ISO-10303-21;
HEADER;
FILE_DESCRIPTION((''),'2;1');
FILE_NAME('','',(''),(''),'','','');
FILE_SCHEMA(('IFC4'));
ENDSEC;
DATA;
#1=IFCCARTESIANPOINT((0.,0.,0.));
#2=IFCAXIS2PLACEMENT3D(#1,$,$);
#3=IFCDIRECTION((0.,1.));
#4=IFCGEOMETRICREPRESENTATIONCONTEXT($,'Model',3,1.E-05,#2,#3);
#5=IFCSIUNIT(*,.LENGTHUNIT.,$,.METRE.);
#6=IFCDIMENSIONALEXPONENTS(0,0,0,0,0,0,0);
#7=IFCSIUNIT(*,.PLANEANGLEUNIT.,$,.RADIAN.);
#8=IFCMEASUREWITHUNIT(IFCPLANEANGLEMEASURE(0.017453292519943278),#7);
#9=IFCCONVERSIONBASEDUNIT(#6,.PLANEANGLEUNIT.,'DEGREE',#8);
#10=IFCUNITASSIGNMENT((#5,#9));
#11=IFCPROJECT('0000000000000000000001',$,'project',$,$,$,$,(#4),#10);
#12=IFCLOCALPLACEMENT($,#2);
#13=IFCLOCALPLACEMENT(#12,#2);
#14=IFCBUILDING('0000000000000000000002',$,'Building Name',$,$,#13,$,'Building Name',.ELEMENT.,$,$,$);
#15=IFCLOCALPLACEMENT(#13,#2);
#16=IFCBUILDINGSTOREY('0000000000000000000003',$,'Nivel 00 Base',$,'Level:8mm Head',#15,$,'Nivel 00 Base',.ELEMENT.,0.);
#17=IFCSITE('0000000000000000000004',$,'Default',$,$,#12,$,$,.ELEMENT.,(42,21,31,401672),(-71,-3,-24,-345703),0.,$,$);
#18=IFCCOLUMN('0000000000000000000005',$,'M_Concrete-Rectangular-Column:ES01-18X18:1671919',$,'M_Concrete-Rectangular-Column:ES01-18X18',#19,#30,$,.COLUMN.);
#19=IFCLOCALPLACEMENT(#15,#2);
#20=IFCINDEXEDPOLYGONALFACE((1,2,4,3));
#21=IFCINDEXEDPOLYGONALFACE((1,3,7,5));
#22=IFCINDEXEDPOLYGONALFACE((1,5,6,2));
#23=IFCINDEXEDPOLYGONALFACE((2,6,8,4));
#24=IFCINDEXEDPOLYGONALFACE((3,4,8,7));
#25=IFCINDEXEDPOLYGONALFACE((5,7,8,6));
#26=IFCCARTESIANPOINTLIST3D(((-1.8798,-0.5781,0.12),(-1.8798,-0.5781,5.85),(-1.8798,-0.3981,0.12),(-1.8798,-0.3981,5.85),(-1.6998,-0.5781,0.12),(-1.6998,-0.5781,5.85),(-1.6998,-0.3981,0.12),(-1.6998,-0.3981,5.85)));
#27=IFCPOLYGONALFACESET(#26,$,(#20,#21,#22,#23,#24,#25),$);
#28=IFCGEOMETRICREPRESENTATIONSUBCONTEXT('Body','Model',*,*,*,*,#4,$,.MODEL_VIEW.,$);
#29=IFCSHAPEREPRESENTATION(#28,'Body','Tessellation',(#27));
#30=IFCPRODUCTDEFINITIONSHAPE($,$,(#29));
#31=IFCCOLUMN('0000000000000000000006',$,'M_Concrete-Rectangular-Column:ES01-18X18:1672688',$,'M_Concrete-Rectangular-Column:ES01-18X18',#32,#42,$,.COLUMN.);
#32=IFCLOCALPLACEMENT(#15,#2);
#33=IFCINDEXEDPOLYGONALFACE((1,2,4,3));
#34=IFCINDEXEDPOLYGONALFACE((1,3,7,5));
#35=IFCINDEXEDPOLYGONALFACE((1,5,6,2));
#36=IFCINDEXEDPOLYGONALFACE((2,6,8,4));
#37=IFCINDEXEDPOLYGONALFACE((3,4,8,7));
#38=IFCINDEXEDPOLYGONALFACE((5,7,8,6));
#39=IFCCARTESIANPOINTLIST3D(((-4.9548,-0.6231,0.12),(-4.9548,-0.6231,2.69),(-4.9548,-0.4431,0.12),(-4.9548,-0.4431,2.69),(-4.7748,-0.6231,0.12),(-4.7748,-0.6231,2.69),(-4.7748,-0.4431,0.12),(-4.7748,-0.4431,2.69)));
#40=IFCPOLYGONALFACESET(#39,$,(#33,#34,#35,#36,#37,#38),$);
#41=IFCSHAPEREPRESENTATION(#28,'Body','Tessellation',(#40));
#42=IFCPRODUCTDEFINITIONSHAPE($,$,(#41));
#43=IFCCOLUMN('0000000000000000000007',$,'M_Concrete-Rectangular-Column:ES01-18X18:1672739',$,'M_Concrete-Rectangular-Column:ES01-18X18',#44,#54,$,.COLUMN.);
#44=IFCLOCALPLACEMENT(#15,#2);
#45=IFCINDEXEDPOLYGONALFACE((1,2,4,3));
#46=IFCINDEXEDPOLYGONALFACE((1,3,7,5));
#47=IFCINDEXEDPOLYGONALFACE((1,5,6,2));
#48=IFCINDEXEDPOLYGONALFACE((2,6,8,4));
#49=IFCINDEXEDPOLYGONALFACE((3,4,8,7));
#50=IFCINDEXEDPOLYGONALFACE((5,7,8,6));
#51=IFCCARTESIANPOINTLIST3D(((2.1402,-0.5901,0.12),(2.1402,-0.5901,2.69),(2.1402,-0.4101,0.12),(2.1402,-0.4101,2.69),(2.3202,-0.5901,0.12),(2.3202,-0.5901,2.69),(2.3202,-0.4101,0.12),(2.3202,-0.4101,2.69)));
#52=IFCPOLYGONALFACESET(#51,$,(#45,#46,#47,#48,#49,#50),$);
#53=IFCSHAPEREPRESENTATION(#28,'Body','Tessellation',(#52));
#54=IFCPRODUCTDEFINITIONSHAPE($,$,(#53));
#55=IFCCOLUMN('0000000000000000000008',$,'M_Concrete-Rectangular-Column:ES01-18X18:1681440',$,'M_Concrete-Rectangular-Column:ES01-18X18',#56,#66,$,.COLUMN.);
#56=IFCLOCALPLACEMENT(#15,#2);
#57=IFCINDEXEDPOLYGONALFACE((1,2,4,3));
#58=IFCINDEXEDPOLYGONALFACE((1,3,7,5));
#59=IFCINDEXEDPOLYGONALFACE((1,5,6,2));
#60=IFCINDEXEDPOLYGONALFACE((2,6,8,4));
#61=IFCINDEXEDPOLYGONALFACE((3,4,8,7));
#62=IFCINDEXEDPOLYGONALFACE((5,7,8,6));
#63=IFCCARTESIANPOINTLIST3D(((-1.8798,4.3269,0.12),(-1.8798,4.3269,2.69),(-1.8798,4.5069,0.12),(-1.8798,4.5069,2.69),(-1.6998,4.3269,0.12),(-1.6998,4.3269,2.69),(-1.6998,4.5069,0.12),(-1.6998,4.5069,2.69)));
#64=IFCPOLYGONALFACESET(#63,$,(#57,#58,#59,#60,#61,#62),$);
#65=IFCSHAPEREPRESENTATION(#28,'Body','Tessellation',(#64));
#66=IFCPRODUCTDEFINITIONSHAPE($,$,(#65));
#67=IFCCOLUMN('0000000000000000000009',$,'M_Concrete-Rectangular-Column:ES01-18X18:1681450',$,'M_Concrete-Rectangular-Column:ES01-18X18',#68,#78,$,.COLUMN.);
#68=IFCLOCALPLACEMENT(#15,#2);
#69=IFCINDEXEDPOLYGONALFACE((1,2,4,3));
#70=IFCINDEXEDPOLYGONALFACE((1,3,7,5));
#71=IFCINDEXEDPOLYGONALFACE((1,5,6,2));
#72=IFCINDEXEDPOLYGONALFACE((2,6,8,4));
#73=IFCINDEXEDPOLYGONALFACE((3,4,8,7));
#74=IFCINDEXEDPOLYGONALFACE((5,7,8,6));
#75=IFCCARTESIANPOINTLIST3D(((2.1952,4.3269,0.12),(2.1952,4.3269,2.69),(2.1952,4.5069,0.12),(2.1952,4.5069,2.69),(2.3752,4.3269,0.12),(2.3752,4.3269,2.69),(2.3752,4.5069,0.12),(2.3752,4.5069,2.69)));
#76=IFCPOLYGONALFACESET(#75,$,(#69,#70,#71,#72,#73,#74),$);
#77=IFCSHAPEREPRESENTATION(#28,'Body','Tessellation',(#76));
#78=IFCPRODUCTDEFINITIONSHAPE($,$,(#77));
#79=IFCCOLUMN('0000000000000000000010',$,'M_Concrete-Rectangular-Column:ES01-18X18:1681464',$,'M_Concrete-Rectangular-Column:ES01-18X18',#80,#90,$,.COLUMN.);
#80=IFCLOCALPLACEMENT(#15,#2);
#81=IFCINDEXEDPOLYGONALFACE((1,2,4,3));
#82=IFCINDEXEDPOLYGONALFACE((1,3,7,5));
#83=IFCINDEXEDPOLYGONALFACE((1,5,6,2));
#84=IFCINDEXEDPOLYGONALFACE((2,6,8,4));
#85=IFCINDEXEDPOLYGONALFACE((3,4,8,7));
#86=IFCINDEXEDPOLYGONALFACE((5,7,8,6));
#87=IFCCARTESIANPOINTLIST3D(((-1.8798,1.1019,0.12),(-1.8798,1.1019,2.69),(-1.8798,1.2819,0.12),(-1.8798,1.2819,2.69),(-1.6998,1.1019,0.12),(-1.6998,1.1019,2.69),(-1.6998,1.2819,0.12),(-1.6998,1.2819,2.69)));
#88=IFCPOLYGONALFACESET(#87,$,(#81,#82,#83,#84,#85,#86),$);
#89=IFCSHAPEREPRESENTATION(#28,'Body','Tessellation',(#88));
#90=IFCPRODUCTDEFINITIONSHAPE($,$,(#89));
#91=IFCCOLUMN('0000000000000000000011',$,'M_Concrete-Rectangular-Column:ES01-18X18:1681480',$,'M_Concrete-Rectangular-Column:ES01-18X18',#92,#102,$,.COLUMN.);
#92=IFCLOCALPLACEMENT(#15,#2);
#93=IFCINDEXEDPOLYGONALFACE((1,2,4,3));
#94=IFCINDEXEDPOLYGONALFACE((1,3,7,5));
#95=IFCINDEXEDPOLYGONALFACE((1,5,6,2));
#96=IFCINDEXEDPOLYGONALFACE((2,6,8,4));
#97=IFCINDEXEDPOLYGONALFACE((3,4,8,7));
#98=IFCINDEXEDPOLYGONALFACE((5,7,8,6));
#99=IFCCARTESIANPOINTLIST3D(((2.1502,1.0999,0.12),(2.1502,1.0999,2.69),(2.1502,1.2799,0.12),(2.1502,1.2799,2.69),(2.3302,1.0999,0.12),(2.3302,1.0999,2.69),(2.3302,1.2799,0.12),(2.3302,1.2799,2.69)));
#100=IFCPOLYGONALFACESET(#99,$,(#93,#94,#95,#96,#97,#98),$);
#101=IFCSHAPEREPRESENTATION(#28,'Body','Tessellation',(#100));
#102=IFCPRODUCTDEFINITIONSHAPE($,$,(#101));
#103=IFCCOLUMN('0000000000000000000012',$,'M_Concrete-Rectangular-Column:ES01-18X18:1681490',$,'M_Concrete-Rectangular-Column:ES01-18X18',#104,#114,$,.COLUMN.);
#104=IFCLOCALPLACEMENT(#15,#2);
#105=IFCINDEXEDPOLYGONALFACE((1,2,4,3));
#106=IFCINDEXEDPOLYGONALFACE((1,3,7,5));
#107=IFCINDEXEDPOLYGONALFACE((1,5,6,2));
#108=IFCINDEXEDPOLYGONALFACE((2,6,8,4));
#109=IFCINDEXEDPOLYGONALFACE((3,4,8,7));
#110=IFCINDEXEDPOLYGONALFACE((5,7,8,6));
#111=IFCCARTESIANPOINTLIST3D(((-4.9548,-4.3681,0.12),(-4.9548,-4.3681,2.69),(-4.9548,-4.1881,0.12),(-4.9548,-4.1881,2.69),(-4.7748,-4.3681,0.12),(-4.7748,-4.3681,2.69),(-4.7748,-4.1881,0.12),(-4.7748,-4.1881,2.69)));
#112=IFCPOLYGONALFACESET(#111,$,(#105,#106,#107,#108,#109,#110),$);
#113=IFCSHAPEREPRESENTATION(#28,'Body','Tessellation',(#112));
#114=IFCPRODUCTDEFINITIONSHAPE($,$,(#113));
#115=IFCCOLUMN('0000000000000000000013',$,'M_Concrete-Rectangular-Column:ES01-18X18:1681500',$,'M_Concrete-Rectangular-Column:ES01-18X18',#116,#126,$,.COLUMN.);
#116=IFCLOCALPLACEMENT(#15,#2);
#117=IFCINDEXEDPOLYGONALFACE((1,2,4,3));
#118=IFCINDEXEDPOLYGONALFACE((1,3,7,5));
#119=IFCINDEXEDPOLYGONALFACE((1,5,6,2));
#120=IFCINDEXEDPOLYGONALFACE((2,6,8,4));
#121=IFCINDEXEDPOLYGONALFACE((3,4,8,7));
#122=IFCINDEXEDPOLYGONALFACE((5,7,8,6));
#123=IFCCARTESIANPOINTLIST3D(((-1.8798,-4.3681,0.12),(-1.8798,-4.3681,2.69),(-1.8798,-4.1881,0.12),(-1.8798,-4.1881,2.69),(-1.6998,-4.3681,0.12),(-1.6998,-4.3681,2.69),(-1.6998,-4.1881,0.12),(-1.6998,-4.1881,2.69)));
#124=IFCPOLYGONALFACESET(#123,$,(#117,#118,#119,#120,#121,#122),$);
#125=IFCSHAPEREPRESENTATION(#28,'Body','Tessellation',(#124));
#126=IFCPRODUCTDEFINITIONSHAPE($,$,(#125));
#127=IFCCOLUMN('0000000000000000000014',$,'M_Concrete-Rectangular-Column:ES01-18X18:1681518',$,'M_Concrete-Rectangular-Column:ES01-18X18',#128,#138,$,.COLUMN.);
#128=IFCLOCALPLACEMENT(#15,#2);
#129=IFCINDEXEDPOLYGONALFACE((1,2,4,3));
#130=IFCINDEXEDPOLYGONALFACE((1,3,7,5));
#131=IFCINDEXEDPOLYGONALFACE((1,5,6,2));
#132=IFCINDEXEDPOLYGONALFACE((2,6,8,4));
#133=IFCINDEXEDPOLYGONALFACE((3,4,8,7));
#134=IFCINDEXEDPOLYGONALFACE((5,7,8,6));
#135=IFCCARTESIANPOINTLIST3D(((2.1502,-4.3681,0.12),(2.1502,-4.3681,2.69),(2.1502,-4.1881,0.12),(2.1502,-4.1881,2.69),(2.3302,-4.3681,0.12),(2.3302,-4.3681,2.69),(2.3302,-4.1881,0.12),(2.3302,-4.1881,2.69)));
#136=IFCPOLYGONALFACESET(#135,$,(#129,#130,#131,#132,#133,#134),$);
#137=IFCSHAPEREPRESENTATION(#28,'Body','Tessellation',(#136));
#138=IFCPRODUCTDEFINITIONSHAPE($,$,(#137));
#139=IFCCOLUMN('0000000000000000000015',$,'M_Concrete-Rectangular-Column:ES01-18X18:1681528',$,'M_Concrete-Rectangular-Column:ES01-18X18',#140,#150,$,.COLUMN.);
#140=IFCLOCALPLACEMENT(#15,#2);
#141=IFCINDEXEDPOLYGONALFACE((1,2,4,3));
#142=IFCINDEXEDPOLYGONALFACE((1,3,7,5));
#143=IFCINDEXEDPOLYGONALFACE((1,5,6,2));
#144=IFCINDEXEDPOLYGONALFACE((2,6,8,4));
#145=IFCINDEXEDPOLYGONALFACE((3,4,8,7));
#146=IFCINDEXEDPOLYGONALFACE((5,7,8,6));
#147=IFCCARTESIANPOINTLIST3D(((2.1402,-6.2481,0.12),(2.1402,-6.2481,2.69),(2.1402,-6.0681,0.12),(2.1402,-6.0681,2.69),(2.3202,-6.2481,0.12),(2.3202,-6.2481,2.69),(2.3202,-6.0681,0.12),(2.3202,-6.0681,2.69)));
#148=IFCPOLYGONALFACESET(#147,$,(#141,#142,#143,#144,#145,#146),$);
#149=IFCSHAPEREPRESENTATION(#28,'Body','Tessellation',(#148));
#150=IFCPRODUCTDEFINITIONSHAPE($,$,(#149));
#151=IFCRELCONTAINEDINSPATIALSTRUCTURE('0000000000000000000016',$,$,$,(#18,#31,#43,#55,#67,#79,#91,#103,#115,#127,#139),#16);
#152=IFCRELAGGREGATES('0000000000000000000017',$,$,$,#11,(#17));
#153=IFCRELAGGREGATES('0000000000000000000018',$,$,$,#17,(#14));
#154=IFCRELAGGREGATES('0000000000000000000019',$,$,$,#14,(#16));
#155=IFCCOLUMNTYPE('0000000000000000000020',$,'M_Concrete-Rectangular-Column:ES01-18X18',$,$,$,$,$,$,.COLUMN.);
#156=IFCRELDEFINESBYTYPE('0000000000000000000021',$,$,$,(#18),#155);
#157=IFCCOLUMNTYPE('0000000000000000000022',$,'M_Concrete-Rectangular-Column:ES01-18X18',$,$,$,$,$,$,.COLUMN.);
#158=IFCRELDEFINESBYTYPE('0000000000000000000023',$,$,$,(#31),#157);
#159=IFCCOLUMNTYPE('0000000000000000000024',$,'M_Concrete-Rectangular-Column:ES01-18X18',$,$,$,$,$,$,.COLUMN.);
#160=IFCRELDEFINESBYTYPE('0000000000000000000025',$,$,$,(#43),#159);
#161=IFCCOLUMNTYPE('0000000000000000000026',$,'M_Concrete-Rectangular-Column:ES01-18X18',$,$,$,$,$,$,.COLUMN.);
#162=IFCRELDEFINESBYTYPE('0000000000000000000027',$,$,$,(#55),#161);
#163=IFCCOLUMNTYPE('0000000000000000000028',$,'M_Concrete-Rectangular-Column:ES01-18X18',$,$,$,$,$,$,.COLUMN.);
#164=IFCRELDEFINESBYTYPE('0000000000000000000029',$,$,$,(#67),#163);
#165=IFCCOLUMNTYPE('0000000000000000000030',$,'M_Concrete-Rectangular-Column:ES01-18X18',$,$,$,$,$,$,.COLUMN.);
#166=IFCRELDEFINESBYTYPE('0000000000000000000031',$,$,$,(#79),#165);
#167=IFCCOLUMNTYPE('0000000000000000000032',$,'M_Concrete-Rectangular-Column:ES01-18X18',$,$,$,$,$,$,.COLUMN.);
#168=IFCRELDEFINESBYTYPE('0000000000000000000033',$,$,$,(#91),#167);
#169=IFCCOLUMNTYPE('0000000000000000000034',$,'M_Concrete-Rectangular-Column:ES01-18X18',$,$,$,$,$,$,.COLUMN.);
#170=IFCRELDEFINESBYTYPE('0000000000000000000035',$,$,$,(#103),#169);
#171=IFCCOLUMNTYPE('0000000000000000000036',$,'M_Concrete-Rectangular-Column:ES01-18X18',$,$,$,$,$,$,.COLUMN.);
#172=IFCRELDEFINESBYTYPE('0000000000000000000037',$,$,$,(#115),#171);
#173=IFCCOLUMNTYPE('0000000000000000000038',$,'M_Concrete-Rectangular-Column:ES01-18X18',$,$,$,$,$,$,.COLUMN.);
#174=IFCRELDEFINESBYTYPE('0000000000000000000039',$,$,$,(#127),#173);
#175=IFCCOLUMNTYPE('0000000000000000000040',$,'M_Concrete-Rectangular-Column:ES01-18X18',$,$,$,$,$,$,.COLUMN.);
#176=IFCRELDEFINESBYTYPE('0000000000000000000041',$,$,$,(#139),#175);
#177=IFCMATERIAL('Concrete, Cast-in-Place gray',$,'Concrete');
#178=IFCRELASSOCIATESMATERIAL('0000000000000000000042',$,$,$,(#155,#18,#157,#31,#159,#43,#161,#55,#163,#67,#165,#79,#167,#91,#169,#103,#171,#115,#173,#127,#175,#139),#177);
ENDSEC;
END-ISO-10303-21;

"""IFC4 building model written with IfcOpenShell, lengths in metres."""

from ifc_helpers import new_model, entity, si_unit, converted_unit, direction, frame, origin, place, context, subcontext, project, spatial, indexed_curve, outline, extrude, source, transform, mapped, material, type_object, type_shapes, element, save


model = new_model("IFC4")

# Units and contexts
model_context = context("Model", 3, precision=1e-05, world=origin(), true_north=direction((0.0, 1.0)))
body_context = subcontext(model_context, "Body", "Model", "MODEL_VIEW")
ifc_project = project(units=[si_unit("LENGTHUNIT", "METRE"), converted_unit("PLANEANGLEUNIT", "DEGREE", entity("IfcPlaneAngleMeasure", 0.017453292519943278), si_unit("PLANEANGLEUNIT", "RADIAN"), dimensions=[0, 0, 0, 0, 0, 0, 0])], contexts=[model_context])

# Site, building, storey
site_placement = place(None, origin())
site = spatial("IfcSite", under=ifc_project, at=site_placement, Name="Default", CompositionType="ELEMENT", RefLatitude=(42, 21, 31, 401672), RefLongitude=(-71, -3, -24, -345703), RefElevation=0.0)
building_placement = place(site_placement, origin())
building = spatial("IfcBuilding", under=site, at=building_placement, Name="Building Name", LongName="Building Name", CompositionType="ELEMENT")
storey_placement = place(building_placement, origin())
storey = spatial("IfcBuildingStorey", under=building, at=storey_placement, Name="Nivel 00 Base", ObjectType="Level:8mm Head", LongName="Nivel 00 Base", CompositionType="ELEMENT", Elevation=0.0)

# Columns
ifc_material_1 = material(Name="Concrete, Cast-in-Place gray", Category="Concrete")
column_type_1 = type_object("IfcColumnType", Name="M_Concrete-Rectangular-Column:ES01-18X18", PredefinedType="COLUMN", material=ifc_material_1)
shared_shape_1 = source(origin(), body_context, "Body", "SweptSolid", [
    extrude(outline(indexed_curve([(-0.09, -0.09), (0.09, -0.09), (0.09, 0.09), (-0.09, 0.09), (-0.09, -0.09)], self_intersect=False)), frame((-1.7898, -0.4881, 0.12), z_axis=(0.0, 0.0, 1.0), x_axis=(-1.0, 0.0, 0.0)), (0.0, 0.0, 1.0), 5.73),
])
type_shapes(column_type_1, [shared_shape_1])
column_1_placement = place(storey_placement, origin())
element("IfcColumn", 1, at=column_1_placement, inside=storey, type_object=column_type_1, material=ifc_material_1, Name="M_Concrete-Rectangular-Column:ES01-18X18:1671919", ObjectType="M_Concrete-Rectangular-Column:ES01-18X18", PredefinedType="COLUMN", context=body_context, shape_type="MappedRepresentation", body=[
    mapped(shared_shape_1, transform((0.0, 0.0, 0.0), scale=1.0)),
])
column_type_2 = type_object("IfcColumnType", Name="M_Concrete-Rectangular-Column:ES01-18X18", PredefinedType="COLUMN", material=ifc_material_1)
shared_shape_2 = source(origin(), body_context, "Body", "SweptSolid", [
    extrude(outline(indexed_curve([(-0.09, -0.09), (0.09, -0.09), (0.09, 0.09), (-0.09, 0.09), (-0.09, -0.09)], self_intersect=False)), frame((-4.8648, -0.5331, 0.12), z_axis=(0.0, 0.0, 1.0), x_axis=(-1.0, 0.0, 0.0)), (0.0, 0.0, 1.0), 2.57),
])
type_shapes(column_type_2, [shared_shape_2])
column_2_placement = place(storey_placement, origin())
element("IfcColumn", 2, at=column_2_placement, inside=storey, type_object=column_type_2, material=ifc_material_1, Name="M_Concrete-Rectangular-Column:ES01-18X18:1672688", ObjectType="M_Concrete-Rectangular-Column:ES01-18X18", PredefinedType="COLUMN", context=body_context, shape_type="MappedRepresentation", body=[
    mapped(shared_shape_2, transform((0.0, 0.0, 0.0), scale=1.0)),
])
column_type_3 = type_object("IfcColumnType", Name="M_Concrete-Rectangular-Column:ES01-18X18", PredefinedType="COLUMN", material=ifc_material_1)
shared_shape_3 = source(origin(), body_context, "Body", "SweptSolid", [
    extrude(outline(indexed_curve([(-0.09, -0.09), (0.09, -0.09), (0.09, 0.09), (-0.09, 0.09), (-0.09, -0.09)], self_intersect=False)), frame((2.2302, -0.5001, 0.12), z_axis=(0.0, 0.0, 1.0), x_axis=(-1.0, 0.0, 0.0)), (0.0, 0.0, 1.0), 2.57),
])
type_shapes(column_type_3, [shared_shape_3])
column_3_placement = place(storey_placement, origin())
element("IfcColumn", 3, at=column_3_placement, inside=storey, type_object=column_type_3, material=ifc_material_1, Name="M_Concrete-Rectangular-Column:ES01-18X18:1672739", ObjectType="M_Concrete-Rectangular-Column:ES01-18X18", PredefinedType="COLUMN", context=body_context, shape_type="MappedRepresentation", body=[
    mapped(shared_shape_3, transform((0.0, 0.0, 0.0), scale=1.0)),
])
column_type_4 = type_object("IfcColumnType", Name="M_Concrete-Rectangular-Column:ES01-18X18", PredefinedType="COLUMN", material=ifc_material_1)
shared_shape_4 = source(origin(), body_context, "Body", "SweptSolid", [
    extrude(outline(indexed_curve([(-0.09, -0.09), (0.09, -0.09), (0.09, 0.09), (-0.09, 0.09), (-0.09, -0.09)], self_intersect=False)), frame((-1.7898, 4.4169, 0.12), z_axis=(0.0, 0.0, 1.0), x_axis=(-1.0, 0.0, 0.0)), (0.0, 0.0, 1.0), 2.57),
])
type_shapes(column_type_4, [shared_shape_4])
column_4_placement = place(storey_placement, origin())
element("IfcColumn", 4, at=column_4_placement, inside=storey, type_object=column_type_4, material=ifc_material_1, Name="M_Concrete-Rectangular-Column:ES01-18X18:1681440", ObjectType="M_Concrete-Rectangular-Column:ES01-18X18", PredefinedType="COLUMN", context=body_context, shape_type="MappedRepresentation", body=[
    mapped(shared_shape_4, transform((0.0, 0.0, 0.0), scale=1.0)),
])
column_type_5 = type_object("IfcColumnType", Name="M_Concrete-Rectangular-Column:ES01-18X18", PredefinedType="COLUMN", material=ifc_material_1)
shared_shape_5 = source(origin(), body_context, "Body", "SweptSolid", [
    extrude(outline(indexed_curve([(-0.09, -0.09), (0.09, -0.09), (0.09, 0.09), (-0.09, 0.09), (-0.09, -0.09)], self_intersect=False)), frame((2.2852, 4.4169, 0.12), z_axis=(0.0, 0.0, 1.0), x_axis=(-1.0, 0.0, 0.0)), (0.0, 0.0, 1.0), 2.57),
])
type_shapes(column_type_5, [shared_shape_5])
column_5_placement = place(storey_placement, origin())
element("IfcColumn", 5, at=column_5_placement, inside=storey, type_object=column_type_5, material=ifc_material_1, Name="M_Concrete-Rectangular-Column:ES01-18X18:1681450", ObjectType="M_Concrete-Rectangular-Column:ES01-18X18", PredefinedType="COLUMN", context=body_context, shape_type="MappedRepresentation", body=[
    mapped(shared_shape_5, transform((0.0, 0.0, 0.0), scale=1.0)),
])
column_type_6 = type_object("IfcColumnType", Name="M_Concrete-Rectangular-Column:ES01-18X18", PredefinedType="COLUMN", material=ifc_material_1)
shared_shape_6 = source(origin(), body_context, "Body", "SweptSolid", [
    extrude(outline(indexed_curve([(-0.09, -0.09), (0.09, -0.09), (0.09, 0.09), (-0.09, 0.09), (-0.09, -0.09)], self_intersect=False)), frame((-1.7898, 1.1919, 0.12), z_axis=(0.0, 0.0, 1.0), x_axis=(-1.0, 0.0, 0.0)), (0.0, 0.0, 1.0), 2.57),
])
type_shapes(column_type_6, [shared_shape_6])
column_6_placement = place(storey_placement, origin())
element("IfcColumn", 6, at=column_6_placement, inside=storey, type_object=column_type_6, material=ifc_material_1, Name="M_Concrete-Rectangular-Column:ES01-18X18:1681464", ObjectType="M_Concrete-Rectangular-Column:ES01-18X18", PredefinedType="COLUMN", context=body_context, shape_type="MappedRepresentation", body=[
    mapped(shared_shape_6, transform((0.0, 0.0, 0.0), scale=1.0)),
])
column_type_7 = type_object("IfcColumnType", Name="M_Concrete-Rectangular-Column:ES01-18X18", PredefinedType="COLUMN", material=ifc_material_1)
shared_shape_7 = source(origin(), body_context, "Body", "SweptSolid", [
    extrude(outline(indexed_curve([(-0.09, -0.09), (0.09, -0.09), (0.09, 0.09), (-0.09, 0.09), (-0.09, -0.09)], self_intersect=False)), frame((2.2402, 1.1899, 0.12), z_axis=(0.0, 0.0, 1.0), x_axis=(-1.0, 0.0, 0.0)), (0.0, 0.0, 1.0), 2.57),
])
type_shapes(column_type_7, [shared_shape_7])
column_7_placement = place(storey_placement, origin())
element("IfcColumn", 7, at=column_7_placement, inside=storey, type_object=column_type_7, material=ifc_material_1, Name="M_Concrete-Rectangular-Column:ES01-18X18:1681480", ObjectType="M_Concrete-Rectangular-Column:ES01-18X18", PredefinedType="COLUMN", context=body_context, shape_type="MappedRepresentation", body=[
    mapped(shared_shape_7, transform((0.0, 0.0, 0.0), scale=1.0)),
])
column_type_8 = type_object("IfcColumnType", Name="M_Concrete-Rectangular-Column:ES01-18X18", PredefinedType="COLUMN", material=ifc_material_1)
shared_shape_8 = source(origin(), body_context, "Body", "SweptSolid", [
    extrude(outline(indexed_curve([(-0.09, -0.09), (0.09, -0.09), (0.09, 0.09), (-0.09, 0.09), (-0.09, -0.09)], self_intersect=False)), frame((-4.8648, -4.2781, 0.12), z_axis=(0.0, 0.0, 1.0), x_axis=(-1.0, 0.0, 0.0)), (0.0, 0.0, 1.0), 2.57),
])
type_shapes(column_type_8, [shared_shape_8])
column_8_placement = place(storey_placement, origin())
element("IfcColumn", 8, at=column_8_placement, inside=storey, type_object=column_type_8, material=ifc_material_1, Name="M_Concrete-Rectangular-Column:ES01-18X18:1681490", ObjectType="M_Concrete-Rectangular-Column:ES01-18X18", PredefinedType="COLUMN", context=body_context, shape_type="MappedRepresentation", body=[
    mapped(shared_shape_8, transform((0.0, 0.0, 0.0), scale=1.0)),
])
column_type_9 = type_object("IfcColumnType", Name="M_Concrete-Rectangular-Column:ES01-18X18", PredefinedType="COLUMN", material=ifc_material_1)
shared_shape_9 = source(origin(), body_context, "Body", "SweptSolid", [
    extrude(outline(indexed_curve([(-0.09, -0.09), (0.09, -0.09), (0.09, 0.09), (-0.09, 0.09), (-0.09, -0.09)], self_intersect=False)), frame((-1.7898, -4.2781, 0.12), z_axis=(0.0, 0.0, 1.0), x_axis=(-1.0, 0.0, 0.0)), (0.0, 0.0, 1.0), 2.57),
])
type_shapes(column_type_9, [shared_shape_9])
column_9_placement = place(storey_placement, origin())
element("IfcColumn", 9, at=column_9_placement, inside=storey, type_object=column_type_9, material=ifc_material_1, Name="M_Concrete-Rectangular-Column:ES01-18X18:1681500", ObjectType="M_Concrete-Rectangular-Column:ES01-18X18", PredefinedType="COLUMN", context=body_context, shape_type="MappedRepresentation", body=[
    mapped(shared_shape_9, transform((0.0, 0.0, 0.0), scale=1.0)),
])
column_type_10 = type_object("IfcColumnType", Name="M_Concrete-Rectangular-Column:ES01-18X18", PredefinedType="COLUMN", material=ifc_material_1)
shared_shape_10 = source(origin(), body_context, "Body", "SweptSolid", [
    extrude(outline(indexed_curve([(-0.09, -0.09), (0.09, -0.09), (0.09, 0.09), (-0.09, 0.09), (-0.09, -0.09)], self_intersect=False)), frame((2.2402, -4.2781, 0.12), z_axis=(0.0, 0.0, 1.0), x_axis=(-1.0, 0.0, 0.0)), (0.0, 0.0, 1.0), 2.57),
])
type_shapes(column_type_10, [shared_shape_10])
column_10_placement = place(storey_placement, origin())
element("IfcColumn", 10, at=column_10_placement, inside=storey, type_object=column_type_10, material=ifc_material_1, Name="M_Concrete-Rectangular-Column:ES01-18X18:1681518", ObjectType="M_Concrete-Rectangular-Column:ES01-18X18", PredefinedType="COLUMN", context=body_context, shape_type="MappedRepresentation", body=[
    mapped(shared_shape_10, transform((0.0, 0.0, 0.0), scale=1.0)),
])
column_type_11 = type_object("IfcColumnType", Name="M_Concrete-Rectangular-Column:ES01-18X18", PredefinedType="COLUMN", material=ifc_material_1)
shared_shape_11 = source(origin(), body_context, "Body", "SweptSolid", [
    extrude(outline(indexed_curve([(-0.09, -0.09), (0.09, -0.09), (0.09, 0.09), (-0.09, 0.09), (-0.09, -0.09)], self_intersect=False)), frame((2.2302, -6.1581, 0.12), z_axis=(0.0, 0.0, 1.0), x_axis=(-1.0, 0.0, 0.0)), (0.0, 0.0, 1.0), 2.57),
])
type_shapes(column_type_11, [shared_shape_11])
column_11_placement = place(storey_placement, origin())
element("IfcColumn", 11, at=column_11_placement, inside=storey, type_object=column_type_11, material=ifc_material_1, Name="M_Concrete-Rectangular-Column:ES01-18X18:1681528", ObjectType="M_Concrete-Rectangular-Column:ES01-18X18", PredefinedType="COLUMN", context=body_context, shape_type="MappedRepresentation", body=[
    mapped(shared_shape_11, transform((0.0, 0.0, 0.0), scale=1.0)),
])

save(model, "model.ifc")
